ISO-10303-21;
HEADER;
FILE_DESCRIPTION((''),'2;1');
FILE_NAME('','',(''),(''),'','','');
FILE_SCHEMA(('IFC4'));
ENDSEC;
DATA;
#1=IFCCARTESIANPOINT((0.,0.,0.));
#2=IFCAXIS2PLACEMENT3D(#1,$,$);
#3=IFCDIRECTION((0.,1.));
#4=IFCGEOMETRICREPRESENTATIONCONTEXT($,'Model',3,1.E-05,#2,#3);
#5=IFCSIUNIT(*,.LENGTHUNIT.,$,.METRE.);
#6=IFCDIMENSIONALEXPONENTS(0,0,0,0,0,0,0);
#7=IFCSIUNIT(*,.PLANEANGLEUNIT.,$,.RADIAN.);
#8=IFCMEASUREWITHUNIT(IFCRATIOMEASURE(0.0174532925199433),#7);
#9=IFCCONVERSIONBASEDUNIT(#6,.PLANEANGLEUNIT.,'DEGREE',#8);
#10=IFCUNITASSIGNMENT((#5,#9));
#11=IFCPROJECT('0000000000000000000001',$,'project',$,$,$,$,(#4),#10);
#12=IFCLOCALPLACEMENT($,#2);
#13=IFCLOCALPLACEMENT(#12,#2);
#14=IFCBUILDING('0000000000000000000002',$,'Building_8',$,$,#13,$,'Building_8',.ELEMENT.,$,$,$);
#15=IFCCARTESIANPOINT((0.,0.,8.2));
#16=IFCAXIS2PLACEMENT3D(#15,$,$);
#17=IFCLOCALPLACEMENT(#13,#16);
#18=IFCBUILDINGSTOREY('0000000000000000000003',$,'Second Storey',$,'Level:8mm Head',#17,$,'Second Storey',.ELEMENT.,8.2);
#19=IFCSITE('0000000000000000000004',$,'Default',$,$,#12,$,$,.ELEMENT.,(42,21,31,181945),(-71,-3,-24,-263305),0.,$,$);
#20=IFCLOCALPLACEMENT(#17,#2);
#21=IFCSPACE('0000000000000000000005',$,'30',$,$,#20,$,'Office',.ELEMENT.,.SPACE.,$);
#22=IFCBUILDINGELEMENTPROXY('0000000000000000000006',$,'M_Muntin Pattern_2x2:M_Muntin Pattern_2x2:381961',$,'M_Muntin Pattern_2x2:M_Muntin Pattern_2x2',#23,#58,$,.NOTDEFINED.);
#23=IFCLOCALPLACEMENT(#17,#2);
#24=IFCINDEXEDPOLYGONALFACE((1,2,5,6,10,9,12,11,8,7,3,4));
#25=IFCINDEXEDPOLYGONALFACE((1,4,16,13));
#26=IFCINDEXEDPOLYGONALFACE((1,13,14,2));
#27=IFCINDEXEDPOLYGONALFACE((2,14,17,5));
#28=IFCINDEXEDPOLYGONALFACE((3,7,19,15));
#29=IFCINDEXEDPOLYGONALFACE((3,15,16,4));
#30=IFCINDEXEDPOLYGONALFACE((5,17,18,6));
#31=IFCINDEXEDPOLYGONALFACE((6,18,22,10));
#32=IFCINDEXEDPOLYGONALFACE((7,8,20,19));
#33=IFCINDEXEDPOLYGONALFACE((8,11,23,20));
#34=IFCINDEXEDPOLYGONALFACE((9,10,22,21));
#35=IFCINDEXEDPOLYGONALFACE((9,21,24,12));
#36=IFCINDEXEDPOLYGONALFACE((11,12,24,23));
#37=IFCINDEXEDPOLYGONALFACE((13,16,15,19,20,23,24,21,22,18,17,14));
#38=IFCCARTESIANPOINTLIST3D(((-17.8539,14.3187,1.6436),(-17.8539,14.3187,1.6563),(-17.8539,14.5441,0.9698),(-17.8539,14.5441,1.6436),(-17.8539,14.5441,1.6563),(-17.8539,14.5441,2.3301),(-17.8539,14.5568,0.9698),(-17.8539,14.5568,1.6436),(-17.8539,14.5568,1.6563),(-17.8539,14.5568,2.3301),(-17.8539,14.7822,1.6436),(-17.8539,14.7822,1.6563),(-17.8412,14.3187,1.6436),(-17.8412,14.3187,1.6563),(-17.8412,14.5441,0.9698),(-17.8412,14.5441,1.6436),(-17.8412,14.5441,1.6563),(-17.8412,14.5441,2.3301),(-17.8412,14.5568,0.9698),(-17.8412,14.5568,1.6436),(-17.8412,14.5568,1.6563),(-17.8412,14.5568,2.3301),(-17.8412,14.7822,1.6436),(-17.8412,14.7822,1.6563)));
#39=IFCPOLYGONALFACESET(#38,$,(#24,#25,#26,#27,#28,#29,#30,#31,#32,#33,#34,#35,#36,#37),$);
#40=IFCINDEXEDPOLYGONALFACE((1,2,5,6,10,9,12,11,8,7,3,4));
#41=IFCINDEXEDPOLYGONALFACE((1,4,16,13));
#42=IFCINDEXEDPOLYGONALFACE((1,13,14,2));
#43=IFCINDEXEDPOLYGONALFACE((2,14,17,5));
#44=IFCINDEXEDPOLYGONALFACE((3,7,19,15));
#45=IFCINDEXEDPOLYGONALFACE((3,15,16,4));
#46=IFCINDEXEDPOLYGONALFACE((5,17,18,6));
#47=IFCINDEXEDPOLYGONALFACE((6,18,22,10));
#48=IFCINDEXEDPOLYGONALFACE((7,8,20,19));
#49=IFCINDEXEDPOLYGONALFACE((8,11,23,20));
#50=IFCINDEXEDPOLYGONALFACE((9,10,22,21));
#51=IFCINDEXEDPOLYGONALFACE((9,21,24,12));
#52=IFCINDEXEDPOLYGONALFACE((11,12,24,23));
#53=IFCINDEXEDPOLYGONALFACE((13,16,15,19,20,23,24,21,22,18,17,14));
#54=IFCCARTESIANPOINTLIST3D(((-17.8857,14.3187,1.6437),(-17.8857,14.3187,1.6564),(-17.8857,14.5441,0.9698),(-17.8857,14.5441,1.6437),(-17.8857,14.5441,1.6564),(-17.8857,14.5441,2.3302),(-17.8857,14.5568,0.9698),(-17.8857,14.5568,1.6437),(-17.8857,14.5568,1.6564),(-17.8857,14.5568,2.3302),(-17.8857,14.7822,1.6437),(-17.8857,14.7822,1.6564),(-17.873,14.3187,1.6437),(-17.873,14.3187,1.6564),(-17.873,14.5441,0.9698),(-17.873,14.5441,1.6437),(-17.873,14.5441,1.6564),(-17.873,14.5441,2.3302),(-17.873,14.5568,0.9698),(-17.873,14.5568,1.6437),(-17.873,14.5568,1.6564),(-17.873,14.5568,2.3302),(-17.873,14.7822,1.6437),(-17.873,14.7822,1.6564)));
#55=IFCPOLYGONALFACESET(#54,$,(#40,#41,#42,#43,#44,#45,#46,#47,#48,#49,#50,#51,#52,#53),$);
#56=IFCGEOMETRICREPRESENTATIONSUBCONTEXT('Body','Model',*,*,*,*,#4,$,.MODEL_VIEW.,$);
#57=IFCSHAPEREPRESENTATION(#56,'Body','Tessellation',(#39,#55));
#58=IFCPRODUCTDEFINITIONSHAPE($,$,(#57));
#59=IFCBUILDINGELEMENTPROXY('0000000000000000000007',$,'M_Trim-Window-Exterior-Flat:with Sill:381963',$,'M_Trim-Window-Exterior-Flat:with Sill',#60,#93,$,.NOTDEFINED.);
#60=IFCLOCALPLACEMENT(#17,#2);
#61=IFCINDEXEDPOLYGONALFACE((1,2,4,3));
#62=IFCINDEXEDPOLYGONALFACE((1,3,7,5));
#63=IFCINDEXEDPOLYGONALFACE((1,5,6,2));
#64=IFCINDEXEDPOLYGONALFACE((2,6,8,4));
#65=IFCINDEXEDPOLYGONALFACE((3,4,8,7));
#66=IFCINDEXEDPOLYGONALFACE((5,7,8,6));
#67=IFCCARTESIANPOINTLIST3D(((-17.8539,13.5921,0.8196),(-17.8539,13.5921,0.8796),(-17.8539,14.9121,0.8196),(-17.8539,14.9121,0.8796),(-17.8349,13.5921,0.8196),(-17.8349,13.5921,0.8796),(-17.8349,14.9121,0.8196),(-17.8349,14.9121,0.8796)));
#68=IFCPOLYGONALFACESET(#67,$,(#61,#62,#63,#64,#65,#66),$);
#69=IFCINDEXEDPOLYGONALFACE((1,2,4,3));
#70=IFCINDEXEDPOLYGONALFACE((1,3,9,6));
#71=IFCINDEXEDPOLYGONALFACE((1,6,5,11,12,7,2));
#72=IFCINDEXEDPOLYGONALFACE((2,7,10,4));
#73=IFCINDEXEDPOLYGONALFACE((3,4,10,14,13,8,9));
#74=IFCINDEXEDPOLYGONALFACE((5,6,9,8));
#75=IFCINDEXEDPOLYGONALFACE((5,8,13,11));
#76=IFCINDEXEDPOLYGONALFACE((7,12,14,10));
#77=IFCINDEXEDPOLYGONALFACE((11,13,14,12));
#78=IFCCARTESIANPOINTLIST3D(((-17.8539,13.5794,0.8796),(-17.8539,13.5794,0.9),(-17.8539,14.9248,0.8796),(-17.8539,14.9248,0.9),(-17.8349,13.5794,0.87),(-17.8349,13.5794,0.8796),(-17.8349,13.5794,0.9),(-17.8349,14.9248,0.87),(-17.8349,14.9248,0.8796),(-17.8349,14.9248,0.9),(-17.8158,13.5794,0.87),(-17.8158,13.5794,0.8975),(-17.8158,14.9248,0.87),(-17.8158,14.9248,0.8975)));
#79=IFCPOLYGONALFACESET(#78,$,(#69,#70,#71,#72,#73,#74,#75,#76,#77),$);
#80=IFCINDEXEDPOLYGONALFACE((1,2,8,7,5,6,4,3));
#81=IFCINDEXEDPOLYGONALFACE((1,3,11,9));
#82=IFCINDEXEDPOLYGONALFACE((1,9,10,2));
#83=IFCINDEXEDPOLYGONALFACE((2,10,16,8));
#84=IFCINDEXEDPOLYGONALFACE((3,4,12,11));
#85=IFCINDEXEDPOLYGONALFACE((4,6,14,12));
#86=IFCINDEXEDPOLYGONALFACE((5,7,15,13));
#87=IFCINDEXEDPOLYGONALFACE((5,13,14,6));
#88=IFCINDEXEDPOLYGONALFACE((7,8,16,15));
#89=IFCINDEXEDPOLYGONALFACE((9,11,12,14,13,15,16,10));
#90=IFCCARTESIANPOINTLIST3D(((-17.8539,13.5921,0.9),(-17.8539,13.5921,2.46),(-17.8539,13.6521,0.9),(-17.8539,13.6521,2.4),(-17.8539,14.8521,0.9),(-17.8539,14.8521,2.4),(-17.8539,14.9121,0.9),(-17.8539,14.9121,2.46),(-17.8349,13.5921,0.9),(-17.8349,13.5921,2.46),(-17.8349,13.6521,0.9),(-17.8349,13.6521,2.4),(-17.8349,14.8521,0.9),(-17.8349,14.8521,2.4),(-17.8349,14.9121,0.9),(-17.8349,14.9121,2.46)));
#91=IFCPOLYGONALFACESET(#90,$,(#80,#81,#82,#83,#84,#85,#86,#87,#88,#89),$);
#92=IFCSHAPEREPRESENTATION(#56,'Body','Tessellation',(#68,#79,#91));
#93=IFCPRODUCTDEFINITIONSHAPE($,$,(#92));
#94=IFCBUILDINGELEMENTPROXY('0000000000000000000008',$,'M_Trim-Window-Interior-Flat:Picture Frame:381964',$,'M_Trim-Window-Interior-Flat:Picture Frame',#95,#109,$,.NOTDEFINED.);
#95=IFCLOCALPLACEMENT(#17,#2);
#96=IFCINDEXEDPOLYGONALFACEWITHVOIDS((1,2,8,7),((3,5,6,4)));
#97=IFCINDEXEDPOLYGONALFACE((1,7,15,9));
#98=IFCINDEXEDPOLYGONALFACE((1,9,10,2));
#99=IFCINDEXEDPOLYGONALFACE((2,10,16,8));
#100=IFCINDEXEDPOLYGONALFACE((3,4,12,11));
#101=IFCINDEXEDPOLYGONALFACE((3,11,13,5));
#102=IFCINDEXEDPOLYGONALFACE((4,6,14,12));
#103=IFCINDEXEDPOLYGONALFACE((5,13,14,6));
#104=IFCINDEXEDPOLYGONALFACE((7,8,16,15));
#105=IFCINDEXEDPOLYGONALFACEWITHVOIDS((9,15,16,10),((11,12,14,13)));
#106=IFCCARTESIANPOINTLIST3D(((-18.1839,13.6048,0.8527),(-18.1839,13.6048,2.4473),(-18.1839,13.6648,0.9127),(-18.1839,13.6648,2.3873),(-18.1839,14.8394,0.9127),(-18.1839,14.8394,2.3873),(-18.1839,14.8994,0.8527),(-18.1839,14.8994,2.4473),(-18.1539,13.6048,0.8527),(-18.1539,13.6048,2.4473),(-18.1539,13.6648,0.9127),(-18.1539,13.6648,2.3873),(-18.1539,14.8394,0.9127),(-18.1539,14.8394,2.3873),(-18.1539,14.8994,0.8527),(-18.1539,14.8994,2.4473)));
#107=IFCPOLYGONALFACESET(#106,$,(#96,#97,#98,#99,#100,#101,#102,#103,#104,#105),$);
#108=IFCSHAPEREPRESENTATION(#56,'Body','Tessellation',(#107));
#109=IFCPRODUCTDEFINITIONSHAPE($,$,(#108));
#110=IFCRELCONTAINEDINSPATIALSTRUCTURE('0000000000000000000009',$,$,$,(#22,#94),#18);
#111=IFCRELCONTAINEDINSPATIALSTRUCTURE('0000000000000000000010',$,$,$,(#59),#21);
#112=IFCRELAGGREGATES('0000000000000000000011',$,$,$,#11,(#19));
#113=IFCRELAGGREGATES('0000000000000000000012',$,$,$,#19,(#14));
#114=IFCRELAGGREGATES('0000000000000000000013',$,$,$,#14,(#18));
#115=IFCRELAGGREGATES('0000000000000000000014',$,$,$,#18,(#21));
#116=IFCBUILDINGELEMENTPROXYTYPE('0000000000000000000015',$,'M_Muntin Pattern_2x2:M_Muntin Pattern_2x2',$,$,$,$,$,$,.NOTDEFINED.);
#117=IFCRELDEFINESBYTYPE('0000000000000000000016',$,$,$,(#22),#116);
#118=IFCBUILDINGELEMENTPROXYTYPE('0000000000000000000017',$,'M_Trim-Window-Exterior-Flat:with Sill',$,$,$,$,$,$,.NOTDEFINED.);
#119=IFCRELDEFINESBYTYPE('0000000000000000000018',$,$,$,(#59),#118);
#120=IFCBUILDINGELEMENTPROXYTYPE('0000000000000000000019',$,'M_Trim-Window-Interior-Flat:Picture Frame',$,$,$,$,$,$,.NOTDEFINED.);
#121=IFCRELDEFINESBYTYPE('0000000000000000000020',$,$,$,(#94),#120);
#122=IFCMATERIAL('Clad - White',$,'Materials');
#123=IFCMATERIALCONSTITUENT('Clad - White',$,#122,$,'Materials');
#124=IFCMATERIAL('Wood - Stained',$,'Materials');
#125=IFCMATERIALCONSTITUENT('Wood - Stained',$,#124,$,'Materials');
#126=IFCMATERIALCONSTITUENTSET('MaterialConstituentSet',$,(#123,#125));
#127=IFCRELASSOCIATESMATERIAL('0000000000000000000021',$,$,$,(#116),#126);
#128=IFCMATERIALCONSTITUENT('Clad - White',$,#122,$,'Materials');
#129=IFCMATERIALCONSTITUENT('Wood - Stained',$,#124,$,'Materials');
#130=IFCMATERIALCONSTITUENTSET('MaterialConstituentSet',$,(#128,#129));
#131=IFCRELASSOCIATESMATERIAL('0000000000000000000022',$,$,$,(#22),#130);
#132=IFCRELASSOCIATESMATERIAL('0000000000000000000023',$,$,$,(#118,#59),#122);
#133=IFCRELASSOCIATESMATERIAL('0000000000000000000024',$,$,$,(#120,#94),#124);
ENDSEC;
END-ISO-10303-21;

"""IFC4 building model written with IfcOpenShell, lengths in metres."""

from ifc_helpers import new_model, entity, si_unit, converted_unit, direction, frame, origin, place, context, subcontext, project, spatial, indexed_curve, outline, extrude, source, transform, mapped, material, constituent, constituent_set, type_object, type_shapes, element, save


model = new_model("IFC4")

# Units and contexts
model_context = context("Model", 3, precision=1e-05, world=origin(), true_north=direction((0.0, 1.0)))
body_context = subcontext(model_context, "Body", "Model", "MODEL_VIEW")
ifc_project = project(units=[si_unit("LENGTHUNIT", "METRE"), converted_unit("PLANEANGLEUNIT", "DEGREE", entity("IfcRatioMeasure", 0.0174532925199433), si_unit("PLANEANGLEUNIT", "RADIAN"), dimensions=[0, 0, 0, 0, 0, 0, 0])], contexts=[model_context])

# Site, building, storey
site_placement = place(None, origin())
site = spatial("IfcSite", under=ifc_project, at=site_placement, Name="Default", CompositionType="ELEMENT", RefLatitude=(42, 21, 31, 181945), RefLongitude=(-71, -3, -24, -263305), RefElevation=0.0)
building_placement = place(site_placement, origin())
building = spatial("IfcBuilding", under=site, at=building_placement, Name="Building_8", LongName="Building_8", CompositionType="ELEMENT")
storey_placement = place(building_placement, frame((0.0, 0.0, 8.2)))
storey = spatial("IfcBuildingStorey", under=building, at=storey_placement, Name="Second Storey", ObjectType="Level:8mm Head", LongName="Second Storey", CompositionType="ELEMENT", Elevation=8.2)

# Shared definitions
ifc_material_1 = material(Name="Clad - White", Category="Materials")
ifc_material_2 = material(Name="Wood - Stained", Category="Materials")

# Building element proxy
ifc_constituent_1 = constituent(ifc_material_1, Name="Clad - White", Category="Materials")
ifc_constituent_2 = constituent(ifc_material_2, Name="Wood - Stained", Category="Materials")
ifc_constituent_set_1 = constituent_set(constituents=[ifc_constituent_1, ifc_constituent_2], Name="MaterialConstituentSet")
ifc_constituent_3 = constituent(ifc_material_1, Name="Clad - White", Category="Materials")
ifc_constituent_4 = constituent(ifc_material_2, Name="Wood - Stained", Category="Materials")
ifc_constituent_set_2 = constituent_set(constituents=[ifc_constituent_3, ifc_constituent_4], Name="MaterialConstituentSet")
building_element_proxy_type_1 = type_object("IfcBuildingElementProxyType", Name="M_Muntin Pattern_2x2:M_Muntin Pattern_2x2", PredefinedType="NOTDEFINED", material=ifc_constituent_set_2)
shared_shape_1 = source(origin(), body_context, "Body", "SweptSolid", [
    extrude(outline(indexed_curve([(0.0064, -0.0064), (0.6801, -0.0064), (0.6801, 0.0063), (0.0064, 0.0063), (0.0064, 0.2317), (-0.0063, 0.2317), (-0.0063, 0.0063), (-0.6802, 0.0063), (-0.6802, -0.0064), (-0.0063, -0.0064), (-0.0063, -0.2317), (0.0064, -0.2317), (0.0064, -0.0064)], self_intersect=False)), frame((0.0, 0.0095, 0.6801), z_axis=(0.0, 1.0, 0.0), x_axis=(0.0, 0.0, 1.0)), (0.0, 0.0, 1.0), 0.0127),
    extrude(outline(indexed_curve([(0.0064, -0.0064), (0.6802, -0.0064), (0.6802, 0.0063), (0.0064, 0.0063), (0.0064, 0.2317), (-0.0063, 0.2317), (-0.0063, 0.0063), (-0.6802, 0.0063), (-0.6802, -0.0064), (-0.0063, -0.0064), (-0.0063, -0.2317), (0.0064, -0.2317), (0.0064, -0.0064)], self_intersect=False)), frame((0.0, -0.0222, 0.6802), z_axis=(0.0, 1.0, 0.0), x_axis=(0.0, 0.0, 1.0)), (0.0, 0.0, 1.0), 0.0127),
])
type_shapes(building_element_proxy_type_1, [shared_shape_1])
proxy_1_placement = place(storey_placement, frame((-17.8634, 14.5505, 0.9698), z_axis=(0.0, 0.0, 1.0), x_axis=(0.0, -1.0, 0.0)))
element("IfcBuildingElementProxy", 1, at=proxy_1_placement, inside=storey, type_object=building_element_proxy_type_1, material=ifc_constituent_set_1, Name="M_Muntin Pattern_2x2:M_Muntin Pattern_2x2:381961", ObjectType="M_Muntin Pattern_2x2:M_Muntin Pattern_2x2", PredefinedType="NOTDEFINED", context=body_context, shape_type="MappedRepresentation", body=[
    mapped(shared_shape_1, transform((0.0, 0.0, 0.0), scale=1.0)),
])

# Shared definitions
space_1_placement = place(storey_placement, origin())
space_1 = spatial("IfcSpace", under=storey, at=space_1_placement, Name="30", LongName="Office", CompositionType="ELEMENT", PredefinedType="SPACE")

# Building element proxies
building_element_proxy_type_2 = type_object("IfcBuildingElementProxyType", Name="M_Trim-Window-Exterior-Flat:with Sill", PredefinedType="NOTDEFINED", material=ifc_material_1)
shared_shape_2 = source(origin(), body_context, "Body", "SweptSolid", [
    extrude(outline(indexed_curve([(-0.66, -0.03), (0.66, -0.03), (0.66, 0.03), (-0.66, 0.03), (-0.66, -0.03)], self_intersect=False)), frame((0.0, -1.5504, 0.0), z_axis=(0.0, 0.0, 1.0), x_axis=(-1.0, 0.0, 0.0)), (0.0, 0.0, 1.0), 0.0191),
    extrude(outline(indexed_curve([(-0.019, -0.0152), (0.0, -0.0152), (0.0, -0.0057), (0.019, -0.0057), (0.019, 0.0148), (0.0, 0.0148), (-0.019, 0.0123), (-0.019, -0.0152)], self_intersect=False)), frame((-0.6727, -1.5148, 0.019), z_axis=(1.0, 0.0, 0.0), x_axis=(0.0, 0.0, -1.0)), (0.0, 0.0, 1.0), 1.3454),
    extrude(outline(indexed_curve([(-0.795, -0.66), (0.765, -0.66), (0.765, -0.6), (-0.735, -0.6), (-0.735, 0.6), (0.765, 0.6), (0.765, 0.66), (-0.795, 0.66), (-0.795, -0.66)], self_intersect=False)), frame((0.0, -0.735, 0.0), z_axis=(0.0, 0.0, 1.0), x_axis=(0.0, -1.0, 0.0)), (0.0, 0.0, 1.0), 0.0191),
])
type_shapes(building_element_proxy_type_2, [shared_shape_2])
proxy_2_placement = place(space_1_placement, frame((-17.8539, 14.2521, 2.4), z_axis=(1.0, 0.0, 0.0), x_axis=(0.0, 1.0, 0.0)))
element("IfcBuildingElementProxy", 2, at=proxy_2_placement, inside=space_1, type_object=building_element_proxy_type_2, material=ifc_material_1, Name="M_Trim-Window-Exterior-Flat:with Sill:381963", ObjectType="M_Trim-Window-Exterior-Flat:with Sill", PredefinedType="NOTDEFINED", context=body_context, shape_type="MappedRepresentation", body=[
    mapped(shared_shape_2, transform((0.0, 0.0, 0.0), scale=1.0)),
])
building_element_proxy_type_3 = type_object("IfcBuildingElementProxyType", Name="M_Trim-Window-Interior-Flat:Picture Frame", PredefinedType="NOTDEFINED", material=ifc_material_2)
shared_shape_3 = source(origin(), body_context, "Body", "SweptSolid", [
    extrude(outline(indexed_curve([(-0.6473, -0.7973), (0.6473, -0.7973), (0.6473, 0.7973), (-0.6473, 0.7973), (-0.6473, -0.7973)], self_intersect=False), holes=[indexed_curve([(-0.5873, -0.7373), (-0.5873, 0.7373), (0.5873, 0.7373), (0.5873, -0.7373), (-0.5873, -0.7373)], self_intersect=False)]), frame((0.0, -0.75, 0.0), z_axis=(0.0, 0.0, 1.0), x_axis=(-1.0, 0.0, 0.0)), (0.0, 0.0, 1.0), 0.03),
])
type_shapes(building_element_proxy_type_3, [shared_shape_3])
proxy_3_placement = place(storey_placement, frame((-18.1539, 14.2521, 2.4), z_axis=(-1.0, 0.0, 0.0), x_axis=(0.0, -1.0, 0.0)))
element("IfcBuildingElementProxy", 3, at=proxy_3_placement, inside=storey, type_object=building_element_proxy_type_3, material=ifc_material_2, Name="M_Trim-Window-Interior-Flat:Picture Frame:381964", ObjectType="M_Trim-Window-Interior-Flat:Picture Frame", PredefinedType="NOTDEFINED", context=body_context, shape_type="MappedRepresentation", body=[
    mapped(shared_shape_3, transform((0.0, 0.0, 0.0), scale=1.0)),
])

save(model, "model.ifc")
